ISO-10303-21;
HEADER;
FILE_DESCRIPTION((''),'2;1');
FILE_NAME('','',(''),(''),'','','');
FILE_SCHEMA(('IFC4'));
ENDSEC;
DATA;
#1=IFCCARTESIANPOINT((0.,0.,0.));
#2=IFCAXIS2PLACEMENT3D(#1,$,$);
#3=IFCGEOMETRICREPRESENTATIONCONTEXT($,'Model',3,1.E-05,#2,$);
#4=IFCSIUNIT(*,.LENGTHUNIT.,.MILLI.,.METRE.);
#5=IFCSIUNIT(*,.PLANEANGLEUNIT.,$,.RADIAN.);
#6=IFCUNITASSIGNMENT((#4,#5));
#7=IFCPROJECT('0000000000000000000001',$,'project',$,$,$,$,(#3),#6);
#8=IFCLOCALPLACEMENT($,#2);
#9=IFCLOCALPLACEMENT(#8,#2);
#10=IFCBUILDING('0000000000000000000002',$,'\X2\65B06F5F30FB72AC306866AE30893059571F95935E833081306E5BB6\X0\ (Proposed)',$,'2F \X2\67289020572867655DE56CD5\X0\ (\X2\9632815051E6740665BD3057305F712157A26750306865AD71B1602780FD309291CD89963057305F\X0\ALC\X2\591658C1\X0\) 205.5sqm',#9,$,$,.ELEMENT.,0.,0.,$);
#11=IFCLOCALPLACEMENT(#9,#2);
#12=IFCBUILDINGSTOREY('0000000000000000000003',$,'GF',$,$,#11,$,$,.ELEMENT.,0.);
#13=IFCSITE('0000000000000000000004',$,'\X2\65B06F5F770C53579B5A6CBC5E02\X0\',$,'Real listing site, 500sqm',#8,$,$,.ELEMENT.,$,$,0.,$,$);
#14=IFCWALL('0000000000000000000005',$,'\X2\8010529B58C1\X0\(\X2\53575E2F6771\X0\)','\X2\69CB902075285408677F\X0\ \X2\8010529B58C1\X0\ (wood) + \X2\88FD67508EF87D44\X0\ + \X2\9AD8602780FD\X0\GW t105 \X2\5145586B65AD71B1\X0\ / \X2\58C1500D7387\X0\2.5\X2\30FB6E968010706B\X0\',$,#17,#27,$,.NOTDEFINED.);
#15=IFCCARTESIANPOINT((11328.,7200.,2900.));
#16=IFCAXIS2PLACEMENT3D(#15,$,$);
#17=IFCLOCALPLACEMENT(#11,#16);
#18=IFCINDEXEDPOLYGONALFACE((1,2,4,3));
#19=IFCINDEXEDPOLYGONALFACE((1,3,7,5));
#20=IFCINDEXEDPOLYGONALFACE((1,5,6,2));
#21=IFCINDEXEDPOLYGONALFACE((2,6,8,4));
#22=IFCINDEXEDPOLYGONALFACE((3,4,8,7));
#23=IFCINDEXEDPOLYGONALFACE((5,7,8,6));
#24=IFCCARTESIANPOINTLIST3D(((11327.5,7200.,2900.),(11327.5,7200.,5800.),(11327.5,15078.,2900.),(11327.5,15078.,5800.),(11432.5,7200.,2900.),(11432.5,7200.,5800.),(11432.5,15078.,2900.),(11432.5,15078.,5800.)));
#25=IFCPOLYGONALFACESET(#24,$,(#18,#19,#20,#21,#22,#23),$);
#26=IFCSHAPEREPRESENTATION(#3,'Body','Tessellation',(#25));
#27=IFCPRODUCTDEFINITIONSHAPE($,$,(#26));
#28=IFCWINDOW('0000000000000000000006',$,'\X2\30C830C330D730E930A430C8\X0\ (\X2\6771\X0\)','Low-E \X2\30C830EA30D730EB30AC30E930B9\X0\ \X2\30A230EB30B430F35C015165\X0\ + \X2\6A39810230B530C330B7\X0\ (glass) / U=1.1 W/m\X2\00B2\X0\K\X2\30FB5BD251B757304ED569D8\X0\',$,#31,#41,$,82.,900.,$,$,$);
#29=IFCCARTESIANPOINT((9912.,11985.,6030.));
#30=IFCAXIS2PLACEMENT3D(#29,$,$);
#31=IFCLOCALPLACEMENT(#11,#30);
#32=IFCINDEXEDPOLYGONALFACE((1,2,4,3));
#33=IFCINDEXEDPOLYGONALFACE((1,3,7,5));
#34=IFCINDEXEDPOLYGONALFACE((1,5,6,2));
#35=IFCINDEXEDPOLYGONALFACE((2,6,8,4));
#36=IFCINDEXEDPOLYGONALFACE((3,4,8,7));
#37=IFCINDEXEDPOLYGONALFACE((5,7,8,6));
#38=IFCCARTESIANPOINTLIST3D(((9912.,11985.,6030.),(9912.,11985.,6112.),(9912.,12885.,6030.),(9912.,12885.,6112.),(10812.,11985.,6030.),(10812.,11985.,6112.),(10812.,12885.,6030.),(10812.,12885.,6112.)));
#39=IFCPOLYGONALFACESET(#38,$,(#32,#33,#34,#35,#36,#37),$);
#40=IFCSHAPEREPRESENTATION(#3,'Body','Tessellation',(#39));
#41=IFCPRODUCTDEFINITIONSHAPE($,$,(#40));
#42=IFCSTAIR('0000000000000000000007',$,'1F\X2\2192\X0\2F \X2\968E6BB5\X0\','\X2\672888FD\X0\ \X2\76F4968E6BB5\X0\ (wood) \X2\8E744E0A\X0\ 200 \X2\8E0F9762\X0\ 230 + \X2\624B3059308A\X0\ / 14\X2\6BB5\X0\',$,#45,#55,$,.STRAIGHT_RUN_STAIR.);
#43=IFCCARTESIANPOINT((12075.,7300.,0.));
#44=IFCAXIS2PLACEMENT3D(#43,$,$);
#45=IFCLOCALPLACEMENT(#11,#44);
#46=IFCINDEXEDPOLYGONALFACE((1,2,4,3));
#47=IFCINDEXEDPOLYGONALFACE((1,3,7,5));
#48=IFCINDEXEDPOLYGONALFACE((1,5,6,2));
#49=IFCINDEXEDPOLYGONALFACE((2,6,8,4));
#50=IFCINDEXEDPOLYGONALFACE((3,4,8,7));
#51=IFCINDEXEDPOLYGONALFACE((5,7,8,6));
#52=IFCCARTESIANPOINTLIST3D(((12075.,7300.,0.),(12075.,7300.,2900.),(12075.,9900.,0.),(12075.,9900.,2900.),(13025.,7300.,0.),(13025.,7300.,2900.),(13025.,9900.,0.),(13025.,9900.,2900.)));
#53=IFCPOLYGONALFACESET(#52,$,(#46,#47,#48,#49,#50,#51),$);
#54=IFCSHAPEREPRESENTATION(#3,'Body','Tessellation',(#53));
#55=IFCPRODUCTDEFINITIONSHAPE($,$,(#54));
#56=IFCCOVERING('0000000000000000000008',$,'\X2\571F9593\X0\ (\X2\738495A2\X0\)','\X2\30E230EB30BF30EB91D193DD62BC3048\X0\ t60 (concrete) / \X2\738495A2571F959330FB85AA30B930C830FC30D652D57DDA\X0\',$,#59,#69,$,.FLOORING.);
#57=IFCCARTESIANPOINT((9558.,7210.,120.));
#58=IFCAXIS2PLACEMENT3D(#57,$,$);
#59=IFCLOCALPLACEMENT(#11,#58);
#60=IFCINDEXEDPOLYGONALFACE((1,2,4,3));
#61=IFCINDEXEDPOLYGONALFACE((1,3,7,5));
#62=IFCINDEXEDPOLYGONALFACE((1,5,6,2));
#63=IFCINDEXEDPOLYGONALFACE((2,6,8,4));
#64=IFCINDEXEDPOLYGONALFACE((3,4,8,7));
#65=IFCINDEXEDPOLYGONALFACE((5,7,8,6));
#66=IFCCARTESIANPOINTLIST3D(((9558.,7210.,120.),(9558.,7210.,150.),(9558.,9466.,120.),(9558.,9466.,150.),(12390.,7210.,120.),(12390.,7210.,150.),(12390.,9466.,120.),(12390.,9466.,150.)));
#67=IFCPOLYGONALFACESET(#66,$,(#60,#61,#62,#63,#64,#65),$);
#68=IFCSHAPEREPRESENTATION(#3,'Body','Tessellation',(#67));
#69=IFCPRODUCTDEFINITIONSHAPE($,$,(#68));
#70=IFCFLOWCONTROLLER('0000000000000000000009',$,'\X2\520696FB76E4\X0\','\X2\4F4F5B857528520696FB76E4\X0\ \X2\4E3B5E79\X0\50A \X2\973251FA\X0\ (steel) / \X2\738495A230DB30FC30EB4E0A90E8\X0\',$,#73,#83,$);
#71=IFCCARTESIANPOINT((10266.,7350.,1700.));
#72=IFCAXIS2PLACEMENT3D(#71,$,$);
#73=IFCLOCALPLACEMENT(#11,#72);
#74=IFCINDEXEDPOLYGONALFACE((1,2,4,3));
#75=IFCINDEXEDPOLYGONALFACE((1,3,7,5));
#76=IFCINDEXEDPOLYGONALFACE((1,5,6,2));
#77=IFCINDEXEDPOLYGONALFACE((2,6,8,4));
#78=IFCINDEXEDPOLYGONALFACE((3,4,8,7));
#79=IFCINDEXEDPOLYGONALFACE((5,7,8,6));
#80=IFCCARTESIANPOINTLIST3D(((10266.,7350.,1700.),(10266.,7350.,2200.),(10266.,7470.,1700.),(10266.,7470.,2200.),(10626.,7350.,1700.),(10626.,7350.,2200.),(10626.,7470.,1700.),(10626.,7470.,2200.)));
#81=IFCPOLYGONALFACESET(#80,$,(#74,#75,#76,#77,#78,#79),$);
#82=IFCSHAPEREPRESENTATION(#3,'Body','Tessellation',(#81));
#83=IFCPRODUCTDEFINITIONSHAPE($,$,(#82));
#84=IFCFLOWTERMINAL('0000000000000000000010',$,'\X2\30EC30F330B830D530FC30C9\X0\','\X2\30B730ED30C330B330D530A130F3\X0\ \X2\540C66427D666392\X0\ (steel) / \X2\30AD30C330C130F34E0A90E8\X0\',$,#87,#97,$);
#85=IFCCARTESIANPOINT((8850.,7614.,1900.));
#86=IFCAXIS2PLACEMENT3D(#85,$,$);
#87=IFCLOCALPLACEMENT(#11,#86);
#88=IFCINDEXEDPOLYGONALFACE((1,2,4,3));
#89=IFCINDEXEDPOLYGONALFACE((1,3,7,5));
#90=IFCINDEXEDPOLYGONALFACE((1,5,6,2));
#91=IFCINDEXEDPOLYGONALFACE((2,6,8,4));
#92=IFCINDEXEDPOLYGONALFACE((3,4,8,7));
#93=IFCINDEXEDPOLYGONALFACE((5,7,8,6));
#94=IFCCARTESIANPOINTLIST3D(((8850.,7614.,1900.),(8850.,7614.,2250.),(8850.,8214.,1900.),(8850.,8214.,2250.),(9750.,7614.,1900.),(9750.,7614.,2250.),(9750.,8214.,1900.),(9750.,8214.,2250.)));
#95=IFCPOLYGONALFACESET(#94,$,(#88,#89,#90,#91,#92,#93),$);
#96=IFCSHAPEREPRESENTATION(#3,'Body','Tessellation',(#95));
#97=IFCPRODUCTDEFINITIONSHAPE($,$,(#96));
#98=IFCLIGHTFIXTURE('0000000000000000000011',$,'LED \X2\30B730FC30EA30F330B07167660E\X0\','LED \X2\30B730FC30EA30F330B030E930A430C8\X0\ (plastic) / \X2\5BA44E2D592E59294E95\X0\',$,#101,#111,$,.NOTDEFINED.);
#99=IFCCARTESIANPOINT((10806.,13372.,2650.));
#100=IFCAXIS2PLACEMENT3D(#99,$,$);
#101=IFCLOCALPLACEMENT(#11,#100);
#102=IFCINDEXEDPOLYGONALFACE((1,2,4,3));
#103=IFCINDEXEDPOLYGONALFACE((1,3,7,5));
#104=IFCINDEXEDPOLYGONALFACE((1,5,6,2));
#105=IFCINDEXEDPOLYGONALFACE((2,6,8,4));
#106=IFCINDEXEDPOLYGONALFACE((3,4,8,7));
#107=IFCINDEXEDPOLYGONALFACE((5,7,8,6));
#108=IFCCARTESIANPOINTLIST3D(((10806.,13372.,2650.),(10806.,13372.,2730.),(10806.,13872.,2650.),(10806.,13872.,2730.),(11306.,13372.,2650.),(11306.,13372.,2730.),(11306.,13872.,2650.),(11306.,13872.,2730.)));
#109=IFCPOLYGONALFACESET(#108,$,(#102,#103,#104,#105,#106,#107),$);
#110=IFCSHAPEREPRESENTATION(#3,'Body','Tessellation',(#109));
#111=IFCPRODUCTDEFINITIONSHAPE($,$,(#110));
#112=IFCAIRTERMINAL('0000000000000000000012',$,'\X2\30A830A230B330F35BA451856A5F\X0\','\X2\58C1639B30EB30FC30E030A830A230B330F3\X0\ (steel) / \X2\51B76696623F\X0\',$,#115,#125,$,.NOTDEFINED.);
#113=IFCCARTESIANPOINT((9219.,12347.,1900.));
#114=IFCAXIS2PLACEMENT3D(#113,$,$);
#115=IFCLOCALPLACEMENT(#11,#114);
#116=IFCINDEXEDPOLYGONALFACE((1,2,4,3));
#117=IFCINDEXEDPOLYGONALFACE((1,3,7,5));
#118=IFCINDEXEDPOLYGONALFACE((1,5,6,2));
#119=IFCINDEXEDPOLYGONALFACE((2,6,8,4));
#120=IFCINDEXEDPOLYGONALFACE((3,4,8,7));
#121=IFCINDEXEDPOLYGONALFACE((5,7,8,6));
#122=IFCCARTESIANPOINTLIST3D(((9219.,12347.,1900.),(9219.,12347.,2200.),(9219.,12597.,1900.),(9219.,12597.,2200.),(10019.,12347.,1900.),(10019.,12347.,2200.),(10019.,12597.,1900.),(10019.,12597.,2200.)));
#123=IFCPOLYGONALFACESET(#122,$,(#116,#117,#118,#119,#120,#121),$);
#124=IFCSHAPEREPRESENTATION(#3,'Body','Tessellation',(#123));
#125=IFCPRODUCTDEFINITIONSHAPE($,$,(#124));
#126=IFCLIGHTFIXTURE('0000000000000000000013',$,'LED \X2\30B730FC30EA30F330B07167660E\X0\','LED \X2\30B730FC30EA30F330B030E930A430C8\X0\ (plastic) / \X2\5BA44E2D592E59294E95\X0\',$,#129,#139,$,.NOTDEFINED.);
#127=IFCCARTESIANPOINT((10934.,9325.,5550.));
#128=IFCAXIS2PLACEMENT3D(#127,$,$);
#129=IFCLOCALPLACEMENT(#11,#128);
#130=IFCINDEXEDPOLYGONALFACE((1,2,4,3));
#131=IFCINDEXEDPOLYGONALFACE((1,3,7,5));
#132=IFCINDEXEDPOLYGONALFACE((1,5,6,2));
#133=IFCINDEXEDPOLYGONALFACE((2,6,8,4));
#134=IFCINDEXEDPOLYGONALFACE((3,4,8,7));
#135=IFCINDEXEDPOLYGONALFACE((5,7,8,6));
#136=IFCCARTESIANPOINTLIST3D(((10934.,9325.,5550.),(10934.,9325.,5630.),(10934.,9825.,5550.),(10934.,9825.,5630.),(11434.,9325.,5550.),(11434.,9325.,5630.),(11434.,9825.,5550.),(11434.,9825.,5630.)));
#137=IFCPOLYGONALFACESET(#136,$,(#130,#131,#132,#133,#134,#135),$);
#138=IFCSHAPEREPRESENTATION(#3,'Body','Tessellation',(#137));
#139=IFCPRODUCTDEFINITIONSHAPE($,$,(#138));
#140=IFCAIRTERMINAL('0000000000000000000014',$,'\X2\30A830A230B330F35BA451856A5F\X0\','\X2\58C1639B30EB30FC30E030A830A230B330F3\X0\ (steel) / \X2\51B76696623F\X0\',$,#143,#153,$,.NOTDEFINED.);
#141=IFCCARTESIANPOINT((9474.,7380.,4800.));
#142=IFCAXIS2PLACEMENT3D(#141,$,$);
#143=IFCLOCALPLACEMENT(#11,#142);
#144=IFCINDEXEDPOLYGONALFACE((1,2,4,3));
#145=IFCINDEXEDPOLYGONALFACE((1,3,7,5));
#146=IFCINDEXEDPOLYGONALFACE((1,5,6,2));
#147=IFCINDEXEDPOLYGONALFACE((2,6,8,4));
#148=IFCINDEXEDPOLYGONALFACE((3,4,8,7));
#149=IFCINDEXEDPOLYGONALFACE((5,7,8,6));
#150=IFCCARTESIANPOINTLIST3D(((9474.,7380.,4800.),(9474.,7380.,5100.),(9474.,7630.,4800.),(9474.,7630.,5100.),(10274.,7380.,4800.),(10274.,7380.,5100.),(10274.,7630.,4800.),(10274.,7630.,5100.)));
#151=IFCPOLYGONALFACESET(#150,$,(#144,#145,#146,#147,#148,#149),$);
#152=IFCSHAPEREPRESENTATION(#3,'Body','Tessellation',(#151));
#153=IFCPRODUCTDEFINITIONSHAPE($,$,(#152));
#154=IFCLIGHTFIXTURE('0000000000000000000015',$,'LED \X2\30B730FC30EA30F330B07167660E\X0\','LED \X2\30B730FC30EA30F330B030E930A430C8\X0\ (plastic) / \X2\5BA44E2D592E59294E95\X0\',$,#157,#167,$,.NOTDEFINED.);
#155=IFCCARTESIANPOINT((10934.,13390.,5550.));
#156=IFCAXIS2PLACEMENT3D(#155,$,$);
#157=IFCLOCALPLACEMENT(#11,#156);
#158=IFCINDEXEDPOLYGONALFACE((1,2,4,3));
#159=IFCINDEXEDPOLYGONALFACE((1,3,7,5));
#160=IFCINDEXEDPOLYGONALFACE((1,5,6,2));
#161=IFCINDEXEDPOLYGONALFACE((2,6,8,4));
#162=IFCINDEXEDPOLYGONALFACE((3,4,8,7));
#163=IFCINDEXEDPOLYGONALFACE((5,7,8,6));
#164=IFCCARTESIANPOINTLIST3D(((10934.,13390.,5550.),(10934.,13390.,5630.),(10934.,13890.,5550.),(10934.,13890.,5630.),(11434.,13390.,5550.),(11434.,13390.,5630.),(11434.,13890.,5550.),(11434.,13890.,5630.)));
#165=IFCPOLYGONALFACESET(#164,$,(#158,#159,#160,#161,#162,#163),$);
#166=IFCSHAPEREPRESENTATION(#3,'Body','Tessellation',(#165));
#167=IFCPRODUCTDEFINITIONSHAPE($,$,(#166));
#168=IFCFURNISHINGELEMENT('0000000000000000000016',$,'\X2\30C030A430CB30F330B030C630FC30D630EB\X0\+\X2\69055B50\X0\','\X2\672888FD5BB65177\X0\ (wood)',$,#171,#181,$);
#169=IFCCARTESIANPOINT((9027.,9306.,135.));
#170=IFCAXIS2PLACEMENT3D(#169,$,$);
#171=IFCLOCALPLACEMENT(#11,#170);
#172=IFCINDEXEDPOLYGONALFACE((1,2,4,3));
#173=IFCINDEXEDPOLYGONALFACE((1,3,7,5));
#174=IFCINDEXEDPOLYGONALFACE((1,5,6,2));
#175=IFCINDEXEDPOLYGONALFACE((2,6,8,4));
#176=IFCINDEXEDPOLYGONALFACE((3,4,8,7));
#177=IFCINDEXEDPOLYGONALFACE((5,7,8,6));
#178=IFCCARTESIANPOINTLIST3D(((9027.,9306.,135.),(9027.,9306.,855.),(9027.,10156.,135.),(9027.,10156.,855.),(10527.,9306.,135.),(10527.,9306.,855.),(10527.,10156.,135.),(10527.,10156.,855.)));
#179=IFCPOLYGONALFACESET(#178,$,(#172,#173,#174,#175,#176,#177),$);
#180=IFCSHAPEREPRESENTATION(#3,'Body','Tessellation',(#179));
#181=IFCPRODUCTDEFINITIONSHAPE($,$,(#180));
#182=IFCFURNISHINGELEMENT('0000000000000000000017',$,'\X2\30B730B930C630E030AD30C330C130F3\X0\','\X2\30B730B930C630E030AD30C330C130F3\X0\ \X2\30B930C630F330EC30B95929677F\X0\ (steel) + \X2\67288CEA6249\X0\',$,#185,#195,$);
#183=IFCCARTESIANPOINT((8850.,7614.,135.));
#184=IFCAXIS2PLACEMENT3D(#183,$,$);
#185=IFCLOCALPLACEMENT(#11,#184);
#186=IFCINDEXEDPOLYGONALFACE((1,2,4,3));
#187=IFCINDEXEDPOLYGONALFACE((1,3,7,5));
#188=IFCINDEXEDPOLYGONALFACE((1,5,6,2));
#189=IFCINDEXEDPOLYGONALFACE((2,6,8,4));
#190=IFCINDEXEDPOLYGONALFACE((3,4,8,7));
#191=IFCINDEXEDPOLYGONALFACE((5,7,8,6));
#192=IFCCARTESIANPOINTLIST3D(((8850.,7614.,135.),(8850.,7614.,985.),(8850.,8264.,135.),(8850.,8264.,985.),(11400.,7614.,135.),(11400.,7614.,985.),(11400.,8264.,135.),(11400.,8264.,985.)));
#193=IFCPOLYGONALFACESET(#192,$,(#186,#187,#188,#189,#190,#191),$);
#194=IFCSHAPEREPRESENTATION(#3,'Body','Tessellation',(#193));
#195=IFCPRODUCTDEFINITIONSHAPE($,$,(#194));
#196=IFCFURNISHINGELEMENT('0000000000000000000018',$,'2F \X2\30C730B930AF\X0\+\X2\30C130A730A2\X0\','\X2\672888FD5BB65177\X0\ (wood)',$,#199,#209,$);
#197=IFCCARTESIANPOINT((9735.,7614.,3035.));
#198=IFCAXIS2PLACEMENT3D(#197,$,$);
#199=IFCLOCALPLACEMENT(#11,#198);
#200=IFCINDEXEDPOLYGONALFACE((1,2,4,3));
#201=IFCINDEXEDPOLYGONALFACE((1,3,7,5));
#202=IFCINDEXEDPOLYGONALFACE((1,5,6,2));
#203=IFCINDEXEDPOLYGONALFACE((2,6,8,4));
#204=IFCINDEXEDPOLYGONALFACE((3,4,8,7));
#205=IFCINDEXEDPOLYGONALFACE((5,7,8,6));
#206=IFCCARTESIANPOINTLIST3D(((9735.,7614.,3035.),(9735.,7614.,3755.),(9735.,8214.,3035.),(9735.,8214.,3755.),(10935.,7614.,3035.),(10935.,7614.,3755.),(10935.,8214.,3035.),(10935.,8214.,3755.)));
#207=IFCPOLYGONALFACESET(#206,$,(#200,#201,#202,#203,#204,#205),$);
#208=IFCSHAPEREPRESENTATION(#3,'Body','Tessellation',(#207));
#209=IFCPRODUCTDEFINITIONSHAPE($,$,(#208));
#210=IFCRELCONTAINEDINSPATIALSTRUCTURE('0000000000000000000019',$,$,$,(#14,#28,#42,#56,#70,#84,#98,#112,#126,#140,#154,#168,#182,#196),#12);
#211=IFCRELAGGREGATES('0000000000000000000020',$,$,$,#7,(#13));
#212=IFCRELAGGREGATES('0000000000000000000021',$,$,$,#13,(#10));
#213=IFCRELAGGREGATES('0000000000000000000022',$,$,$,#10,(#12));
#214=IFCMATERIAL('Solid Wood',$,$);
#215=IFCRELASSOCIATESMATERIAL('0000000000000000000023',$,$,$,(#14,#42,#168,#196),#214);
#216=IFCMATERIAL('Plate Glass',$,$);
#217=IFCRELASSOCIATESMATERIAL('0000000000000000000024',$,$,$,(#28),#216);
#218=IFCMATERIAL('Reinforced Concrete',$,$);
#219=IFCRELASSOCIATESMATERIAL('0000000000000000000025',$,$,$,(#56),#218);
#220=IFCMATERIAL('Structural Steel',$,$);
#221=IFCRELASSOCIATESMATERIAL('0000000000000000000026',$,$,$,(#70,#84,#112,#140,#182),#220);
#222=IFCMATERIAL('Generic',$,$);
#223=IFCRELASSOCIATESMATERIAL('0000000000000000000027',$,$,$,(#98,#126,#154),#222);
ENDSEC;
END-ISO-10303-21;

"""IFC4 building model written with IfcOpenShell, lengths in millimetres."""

from ifc_helpers import new_model, si_unit, frame, frame_2d, origin, place, context, project, spatial, rectangle, extrude, material, element, save


model = new_model("IFC4")

# Units and contexts
model_context = context("Model", 3, precision=1e-05, world=origin())
ifc_project = project(units=[si_unit("LENGTHUNIT", "METRE", prefix="MILLI"), si_unit("PLANEANGLEUNIT", "RADIAN")], contexts=[model_context])

# Site, building, storey
site_placement = place(None, origin())
site = spatial("IfcSite", under=ifc_project, at=site_placement, Name="新潟県南魚沼市", ObjectType="Real listing site, 500sqm", CompositionType="ELEMENT", RefElevation=0.0)
building_placement = place(site_placement, origin())
building = spatial("IfcBuilding", under=site, at=building_placement, Name="新潟・犬と暮らす土間広めの家 (Proposed)", ObjectType="2F 木造在来工法 (防腐処理施した無垢材と断熱性能を重視したALC外壁) 205.5sqm", CompositionType="ELEMENT", ElevationOfRefHeight=0.0, ElevationOfTerrain=0.0)
storey_placement = place(building_placement, origin())
storey = spatial("IfcBuildingStorey", under=building, at=storey_placement, Name="GF", CompositionType="ELEMENT", Elevation=0.0)

# Shared definitions
ifc_material_1 = material(Name="Solid Wood")

# Wall
wall_1_placement = place(storey_placement, frame((11328.0, 7200.0, 2900.0)))
element("IfcWall", 1, at=wall_1_placement, inside=storey, material=ifc_material_1, Name="耐力壁(南帯東)", Description="構造用合板 耐力壁 (wood) + 製材軸組 + 高性能GW t105 充填断熱 / 壁倍率2.5・準耐火", PredefinedType="NOTDEFINED", context=model_context, shape_type="SweptSolid", body=[
    extrude(rectangle(XDim=105.0, YDim=7878.0, at=frame_2d((52.0, 3939.0))), frame((11328.0, 7200.0, 2900.0)), (0.0, 0.0, 1.0), 2900.0),
])

# Window
ifc_material_2 = material(Name="Plate Glass")
window_placement = place(storey_placement, frame((9912.0, 11985.0, 6030.0)))
element("IfcWindow", 2, at=window_placement, inside=storey, material=ifc_material_2, Name="トップライト (東)", Description="Low-E トリプルガラス アルゴン封入 + 樹脂サッシ (glass) / U=1.1 W/m²K・寒冷地仕様", OverallHeight=82.0, OverallWidth=900.0, context=model_context, shape_type="SweptSolid", body=[
    extrude(rectangle(XDim=900.0, YDim=900.0, at=frame_2d((450.0, 450.0))), frame((9912.0, 11985.0, 6030.0)), (0.0, 0.0, 1.0), 82.0),
])

# Stair
stair_placement = place(storey_placement, frame((12075.0, 7300.0, 0.0)))
element("IfcStair", 3, at=stair_placement, inside=storey, material=ifc_material_1, Name="1F→2F 階段", Description="木製 直階段 (wood) 蹴上 200 踏面 230 + 手すり / 14段", PredefinedType="STRAIGHT_RUN_STAIR", context=model_context, shape_type="SweptSolid", body=[
    extrude(rectangle(XDim=950.0, YDim=2600.0, at=frame_2d((475.0, 1300.0))), frame((12075.0, 7300.0, 0.0)), (0.0, 0.0, 1.0), 2900.0),
])

# Covering
ifc_material_3 = material(Name="Reinforced Concrete")
covering_placement = place(storey_placement, frame((9558.0, 7210.0, 120.0)))
element("IfcCovering", 4, at=covering_placement, inside=storey, material=ifc_material_3, Name="土間 (玄関)", Description="モルタル金鏝押え t60 (concrete) / 玄関土間・薪ストーブ動線", PredefinedType="FLOORING", context=model_context, shape_type="SweptSolid", body=[
    extrude(rectangle(XDim=2832.0, YDim=2256.0, at=frame_2d((1416.0, 1128.0))), frame((9558.0, 7210.0, 120.0)), (0.0, 0.0, 1.0), 30.0),
])

# Flow controller
ifc_material_4 = material(Name="Structural Steel")
flow_controller_placement = place(storey_placement, frame((10266.0, 7350.0, 1700.0)))
element("IfcFlowController", 5, at=flow_controller_placement, inside=storey, material=ifc_material_4, Name="分電盤", Description="住宅用分電盤 主幹50A 露出 (steel) / 玄関ホール上部", context=model_context, shape_type="SweptSolid", body=[
    extrude(rectangle(XDim=360.0, YDim=120.0, at=frame_2d((180.0, 60.0))), frame((10266.0, 7350.0, 1700.0)), (0.0, 0.0, 1.0), 500.0),
])

# Flow terminal
flow_terminal_placement = place(storey_placement, frame((8850.0, 7614.0, 1900.0)))
element("IfcFlowTerminal", 6, at=flow_terminal_placement, inside=storey, material=ifc_material_4, Name="レンジフード", Description="シロッコファン 同時給排 (steel) / キッチン上部", context=model_context, shape_type="SweptSolid", body=[
    extrude(rectangle(XDim=900.0, YDim=600.0, at=frame_2d((450.0, 300.0))), frame((8850.0, 7614.0, 1900.0)), (0.0, 0.0, 1.0), 350.0),
])

# Light fixture
ifc_material_5 = material(Name="Generic")
light_fixture_1_placement = place(storey_placement, frame((10806.0, 13372.0, 2650.0)))
element("IfcLightFixture", 7, at=light_fixture_1_placement, inside=storey, material=ifc_material_5, Name="LED シーリング照明", Description="LED シーリングライト (plastic) / 室中央天井", PredefinedType="NOTDEFINED", context=model_context, shape_type="SweptSolid", body=[
    extrude(rectangle(XDim=500.0, YDim=500.0, at=frame_2d((250.0, 250.0))), frame((10806.0, 13372.0, 2650.0)), (0.0, 0.0, 1.0), 80.0),
])

# Air terminal
air_terminal_1_placement = place(storey_placement, frame((9219.0, 12347.0, 1900.0)))
element("IfcAirTerminal", 8, at=air_terminal_1_placement, inside=storey, material=ifc_material_4, Name="エアコン室内機", Description="壁掛ルームエアコン (steel) / 冷暖房", PredefinedType="NOTDEFINED", context=model_context, shape_type="SweptSolid", body=[
    extrude(rectangle(XDim=800.0, YDim=250.0, at=frame_2d((400.0, 125.0))), frame((9219.0, 12347.0, 1900.0)), (0.0, 0.0, 1.0), 300.0),
])

# Light fixture
light_fixture_2_placement = place(storey_placement, frame((10934.0, 9325.0, 5550.0)))
element("IfcLightFixture", 9, at=light_fixture_2_placement, inside=storey, material=ifc_material_5, Name="LED シーリング照明", Description="LED シーリングライト (plastic) / 室中央天井", PredefinedType="NOTDEFINED", context=model_context, shape_type="SweptSolid", body=[
    extrude(rectangle(XDim=500.0, YDim=500.0, at=frame_2d((250.0, 250.0))), frame((10934.0, 9325.0, 5550.0)), (0.0, 0.0, 1.0), 80.0),
])

# Air terminal
air_terminal_2_placement = place(storey_placement, frame((9474.0, 7380.0, 4800.0)))
element("IfcAirTerminal", 10, at=air_terminal_2_placement, inside=storey, material=ifc_material_4, Name="エアコン室内機", Description="壁掛ルームエアコン (steel) / 冷暖房", PredefinedType="NOTDEFINED", context=model_context, shape_type="SweptSolid", body=[
    extrude(rectangle(XDim=800.0, YDim=250.0, at=frame_2d((400.0, 125.0))), frame((9474.0, 7380.0, 4800.0)), (0.0, 0.0, 1.0), 300.0),
])

# Light fixture
light_fixture_3_placement = place(storey_placement, frame((10934.0, 13390.0, 5550.0)))
element("IfcLightFixture", 11, at=light_fixture_3_placement, inside=storey, material=ifc_material_5, Name="LED シーリング照明", Description="LED シーリングライト (plastic) / 室中央天井", PredefinedType="NOTDEFINED", context=model_context, shape_type="SweptSolid", body=[
    extrude(rectangle(XDim=500.0, YDim=500.0, at=frame_2d((250.0, 250.0))), frame((10934.0, 13390.0, 5550.0)), (0.0, 0.0, 1.0), 80.0),
])

# Furnishing elements
furnishing_1_placement = place(storey_placement, frame((9027.0, 9306.0, 135.0)))
element("IfcFurnishingElement", 12, at=furnishing_1_placement, inside=storey, material=ifc_material_1, Name="ダイニングテーブル+椅子", Description="木製家具 (wood)", context=model_context, shape_type="SweptSolid", body=[
    extrude(rectangle(XDim=1500.0, YDim=850.0, at=frame_2d((750.0, 425.0))), frame((9027.0, 9306.0, 135.0)), (0.0, 0.0, 1.0), 720.0),
])
furnishing_2_placement = place(storey_placement, frame((8850.0, 7614.0, 135.0)))
element("IfcFurnishingElement", 13, at=furnishing_2_placement, inside=storey, material=ifc_material_4, Name="システムキッチン", Description="システムキッチン ステンレス天板 (steel) + 木質扉", context=model_context, shape_type="SweptSolid", body=[
    extrude(rectangle(XDim=2550.0, YDim=650.0, at=frame_2d((1275.0, 325.0))), frame((8850.0, 7614.0, 135.0)), (0.0, 0.0, 1.0), 850.0),
])
furnishing_3_placement = place(storey_placement, frame((9735.0, 7614.0, 3035.0)))
element("IfcFurnishingElement", 14, at=furnishing_3_placement, inside=storey, material=ifc_material_1, Name="2F デスク+チェア", Description="木製家具 (wood)", context=model_context, shape_type="SweptSolid", body=[
    extrude(rectangle(XDim=1200.0, YDim=600.0, at=frame_2d((600.0, 300.0))), frame((9735.0, 7614.0, 3035.0)), (0.0, 0.0, 1.0), 720.0),
])

save(model, "model.ifc")
